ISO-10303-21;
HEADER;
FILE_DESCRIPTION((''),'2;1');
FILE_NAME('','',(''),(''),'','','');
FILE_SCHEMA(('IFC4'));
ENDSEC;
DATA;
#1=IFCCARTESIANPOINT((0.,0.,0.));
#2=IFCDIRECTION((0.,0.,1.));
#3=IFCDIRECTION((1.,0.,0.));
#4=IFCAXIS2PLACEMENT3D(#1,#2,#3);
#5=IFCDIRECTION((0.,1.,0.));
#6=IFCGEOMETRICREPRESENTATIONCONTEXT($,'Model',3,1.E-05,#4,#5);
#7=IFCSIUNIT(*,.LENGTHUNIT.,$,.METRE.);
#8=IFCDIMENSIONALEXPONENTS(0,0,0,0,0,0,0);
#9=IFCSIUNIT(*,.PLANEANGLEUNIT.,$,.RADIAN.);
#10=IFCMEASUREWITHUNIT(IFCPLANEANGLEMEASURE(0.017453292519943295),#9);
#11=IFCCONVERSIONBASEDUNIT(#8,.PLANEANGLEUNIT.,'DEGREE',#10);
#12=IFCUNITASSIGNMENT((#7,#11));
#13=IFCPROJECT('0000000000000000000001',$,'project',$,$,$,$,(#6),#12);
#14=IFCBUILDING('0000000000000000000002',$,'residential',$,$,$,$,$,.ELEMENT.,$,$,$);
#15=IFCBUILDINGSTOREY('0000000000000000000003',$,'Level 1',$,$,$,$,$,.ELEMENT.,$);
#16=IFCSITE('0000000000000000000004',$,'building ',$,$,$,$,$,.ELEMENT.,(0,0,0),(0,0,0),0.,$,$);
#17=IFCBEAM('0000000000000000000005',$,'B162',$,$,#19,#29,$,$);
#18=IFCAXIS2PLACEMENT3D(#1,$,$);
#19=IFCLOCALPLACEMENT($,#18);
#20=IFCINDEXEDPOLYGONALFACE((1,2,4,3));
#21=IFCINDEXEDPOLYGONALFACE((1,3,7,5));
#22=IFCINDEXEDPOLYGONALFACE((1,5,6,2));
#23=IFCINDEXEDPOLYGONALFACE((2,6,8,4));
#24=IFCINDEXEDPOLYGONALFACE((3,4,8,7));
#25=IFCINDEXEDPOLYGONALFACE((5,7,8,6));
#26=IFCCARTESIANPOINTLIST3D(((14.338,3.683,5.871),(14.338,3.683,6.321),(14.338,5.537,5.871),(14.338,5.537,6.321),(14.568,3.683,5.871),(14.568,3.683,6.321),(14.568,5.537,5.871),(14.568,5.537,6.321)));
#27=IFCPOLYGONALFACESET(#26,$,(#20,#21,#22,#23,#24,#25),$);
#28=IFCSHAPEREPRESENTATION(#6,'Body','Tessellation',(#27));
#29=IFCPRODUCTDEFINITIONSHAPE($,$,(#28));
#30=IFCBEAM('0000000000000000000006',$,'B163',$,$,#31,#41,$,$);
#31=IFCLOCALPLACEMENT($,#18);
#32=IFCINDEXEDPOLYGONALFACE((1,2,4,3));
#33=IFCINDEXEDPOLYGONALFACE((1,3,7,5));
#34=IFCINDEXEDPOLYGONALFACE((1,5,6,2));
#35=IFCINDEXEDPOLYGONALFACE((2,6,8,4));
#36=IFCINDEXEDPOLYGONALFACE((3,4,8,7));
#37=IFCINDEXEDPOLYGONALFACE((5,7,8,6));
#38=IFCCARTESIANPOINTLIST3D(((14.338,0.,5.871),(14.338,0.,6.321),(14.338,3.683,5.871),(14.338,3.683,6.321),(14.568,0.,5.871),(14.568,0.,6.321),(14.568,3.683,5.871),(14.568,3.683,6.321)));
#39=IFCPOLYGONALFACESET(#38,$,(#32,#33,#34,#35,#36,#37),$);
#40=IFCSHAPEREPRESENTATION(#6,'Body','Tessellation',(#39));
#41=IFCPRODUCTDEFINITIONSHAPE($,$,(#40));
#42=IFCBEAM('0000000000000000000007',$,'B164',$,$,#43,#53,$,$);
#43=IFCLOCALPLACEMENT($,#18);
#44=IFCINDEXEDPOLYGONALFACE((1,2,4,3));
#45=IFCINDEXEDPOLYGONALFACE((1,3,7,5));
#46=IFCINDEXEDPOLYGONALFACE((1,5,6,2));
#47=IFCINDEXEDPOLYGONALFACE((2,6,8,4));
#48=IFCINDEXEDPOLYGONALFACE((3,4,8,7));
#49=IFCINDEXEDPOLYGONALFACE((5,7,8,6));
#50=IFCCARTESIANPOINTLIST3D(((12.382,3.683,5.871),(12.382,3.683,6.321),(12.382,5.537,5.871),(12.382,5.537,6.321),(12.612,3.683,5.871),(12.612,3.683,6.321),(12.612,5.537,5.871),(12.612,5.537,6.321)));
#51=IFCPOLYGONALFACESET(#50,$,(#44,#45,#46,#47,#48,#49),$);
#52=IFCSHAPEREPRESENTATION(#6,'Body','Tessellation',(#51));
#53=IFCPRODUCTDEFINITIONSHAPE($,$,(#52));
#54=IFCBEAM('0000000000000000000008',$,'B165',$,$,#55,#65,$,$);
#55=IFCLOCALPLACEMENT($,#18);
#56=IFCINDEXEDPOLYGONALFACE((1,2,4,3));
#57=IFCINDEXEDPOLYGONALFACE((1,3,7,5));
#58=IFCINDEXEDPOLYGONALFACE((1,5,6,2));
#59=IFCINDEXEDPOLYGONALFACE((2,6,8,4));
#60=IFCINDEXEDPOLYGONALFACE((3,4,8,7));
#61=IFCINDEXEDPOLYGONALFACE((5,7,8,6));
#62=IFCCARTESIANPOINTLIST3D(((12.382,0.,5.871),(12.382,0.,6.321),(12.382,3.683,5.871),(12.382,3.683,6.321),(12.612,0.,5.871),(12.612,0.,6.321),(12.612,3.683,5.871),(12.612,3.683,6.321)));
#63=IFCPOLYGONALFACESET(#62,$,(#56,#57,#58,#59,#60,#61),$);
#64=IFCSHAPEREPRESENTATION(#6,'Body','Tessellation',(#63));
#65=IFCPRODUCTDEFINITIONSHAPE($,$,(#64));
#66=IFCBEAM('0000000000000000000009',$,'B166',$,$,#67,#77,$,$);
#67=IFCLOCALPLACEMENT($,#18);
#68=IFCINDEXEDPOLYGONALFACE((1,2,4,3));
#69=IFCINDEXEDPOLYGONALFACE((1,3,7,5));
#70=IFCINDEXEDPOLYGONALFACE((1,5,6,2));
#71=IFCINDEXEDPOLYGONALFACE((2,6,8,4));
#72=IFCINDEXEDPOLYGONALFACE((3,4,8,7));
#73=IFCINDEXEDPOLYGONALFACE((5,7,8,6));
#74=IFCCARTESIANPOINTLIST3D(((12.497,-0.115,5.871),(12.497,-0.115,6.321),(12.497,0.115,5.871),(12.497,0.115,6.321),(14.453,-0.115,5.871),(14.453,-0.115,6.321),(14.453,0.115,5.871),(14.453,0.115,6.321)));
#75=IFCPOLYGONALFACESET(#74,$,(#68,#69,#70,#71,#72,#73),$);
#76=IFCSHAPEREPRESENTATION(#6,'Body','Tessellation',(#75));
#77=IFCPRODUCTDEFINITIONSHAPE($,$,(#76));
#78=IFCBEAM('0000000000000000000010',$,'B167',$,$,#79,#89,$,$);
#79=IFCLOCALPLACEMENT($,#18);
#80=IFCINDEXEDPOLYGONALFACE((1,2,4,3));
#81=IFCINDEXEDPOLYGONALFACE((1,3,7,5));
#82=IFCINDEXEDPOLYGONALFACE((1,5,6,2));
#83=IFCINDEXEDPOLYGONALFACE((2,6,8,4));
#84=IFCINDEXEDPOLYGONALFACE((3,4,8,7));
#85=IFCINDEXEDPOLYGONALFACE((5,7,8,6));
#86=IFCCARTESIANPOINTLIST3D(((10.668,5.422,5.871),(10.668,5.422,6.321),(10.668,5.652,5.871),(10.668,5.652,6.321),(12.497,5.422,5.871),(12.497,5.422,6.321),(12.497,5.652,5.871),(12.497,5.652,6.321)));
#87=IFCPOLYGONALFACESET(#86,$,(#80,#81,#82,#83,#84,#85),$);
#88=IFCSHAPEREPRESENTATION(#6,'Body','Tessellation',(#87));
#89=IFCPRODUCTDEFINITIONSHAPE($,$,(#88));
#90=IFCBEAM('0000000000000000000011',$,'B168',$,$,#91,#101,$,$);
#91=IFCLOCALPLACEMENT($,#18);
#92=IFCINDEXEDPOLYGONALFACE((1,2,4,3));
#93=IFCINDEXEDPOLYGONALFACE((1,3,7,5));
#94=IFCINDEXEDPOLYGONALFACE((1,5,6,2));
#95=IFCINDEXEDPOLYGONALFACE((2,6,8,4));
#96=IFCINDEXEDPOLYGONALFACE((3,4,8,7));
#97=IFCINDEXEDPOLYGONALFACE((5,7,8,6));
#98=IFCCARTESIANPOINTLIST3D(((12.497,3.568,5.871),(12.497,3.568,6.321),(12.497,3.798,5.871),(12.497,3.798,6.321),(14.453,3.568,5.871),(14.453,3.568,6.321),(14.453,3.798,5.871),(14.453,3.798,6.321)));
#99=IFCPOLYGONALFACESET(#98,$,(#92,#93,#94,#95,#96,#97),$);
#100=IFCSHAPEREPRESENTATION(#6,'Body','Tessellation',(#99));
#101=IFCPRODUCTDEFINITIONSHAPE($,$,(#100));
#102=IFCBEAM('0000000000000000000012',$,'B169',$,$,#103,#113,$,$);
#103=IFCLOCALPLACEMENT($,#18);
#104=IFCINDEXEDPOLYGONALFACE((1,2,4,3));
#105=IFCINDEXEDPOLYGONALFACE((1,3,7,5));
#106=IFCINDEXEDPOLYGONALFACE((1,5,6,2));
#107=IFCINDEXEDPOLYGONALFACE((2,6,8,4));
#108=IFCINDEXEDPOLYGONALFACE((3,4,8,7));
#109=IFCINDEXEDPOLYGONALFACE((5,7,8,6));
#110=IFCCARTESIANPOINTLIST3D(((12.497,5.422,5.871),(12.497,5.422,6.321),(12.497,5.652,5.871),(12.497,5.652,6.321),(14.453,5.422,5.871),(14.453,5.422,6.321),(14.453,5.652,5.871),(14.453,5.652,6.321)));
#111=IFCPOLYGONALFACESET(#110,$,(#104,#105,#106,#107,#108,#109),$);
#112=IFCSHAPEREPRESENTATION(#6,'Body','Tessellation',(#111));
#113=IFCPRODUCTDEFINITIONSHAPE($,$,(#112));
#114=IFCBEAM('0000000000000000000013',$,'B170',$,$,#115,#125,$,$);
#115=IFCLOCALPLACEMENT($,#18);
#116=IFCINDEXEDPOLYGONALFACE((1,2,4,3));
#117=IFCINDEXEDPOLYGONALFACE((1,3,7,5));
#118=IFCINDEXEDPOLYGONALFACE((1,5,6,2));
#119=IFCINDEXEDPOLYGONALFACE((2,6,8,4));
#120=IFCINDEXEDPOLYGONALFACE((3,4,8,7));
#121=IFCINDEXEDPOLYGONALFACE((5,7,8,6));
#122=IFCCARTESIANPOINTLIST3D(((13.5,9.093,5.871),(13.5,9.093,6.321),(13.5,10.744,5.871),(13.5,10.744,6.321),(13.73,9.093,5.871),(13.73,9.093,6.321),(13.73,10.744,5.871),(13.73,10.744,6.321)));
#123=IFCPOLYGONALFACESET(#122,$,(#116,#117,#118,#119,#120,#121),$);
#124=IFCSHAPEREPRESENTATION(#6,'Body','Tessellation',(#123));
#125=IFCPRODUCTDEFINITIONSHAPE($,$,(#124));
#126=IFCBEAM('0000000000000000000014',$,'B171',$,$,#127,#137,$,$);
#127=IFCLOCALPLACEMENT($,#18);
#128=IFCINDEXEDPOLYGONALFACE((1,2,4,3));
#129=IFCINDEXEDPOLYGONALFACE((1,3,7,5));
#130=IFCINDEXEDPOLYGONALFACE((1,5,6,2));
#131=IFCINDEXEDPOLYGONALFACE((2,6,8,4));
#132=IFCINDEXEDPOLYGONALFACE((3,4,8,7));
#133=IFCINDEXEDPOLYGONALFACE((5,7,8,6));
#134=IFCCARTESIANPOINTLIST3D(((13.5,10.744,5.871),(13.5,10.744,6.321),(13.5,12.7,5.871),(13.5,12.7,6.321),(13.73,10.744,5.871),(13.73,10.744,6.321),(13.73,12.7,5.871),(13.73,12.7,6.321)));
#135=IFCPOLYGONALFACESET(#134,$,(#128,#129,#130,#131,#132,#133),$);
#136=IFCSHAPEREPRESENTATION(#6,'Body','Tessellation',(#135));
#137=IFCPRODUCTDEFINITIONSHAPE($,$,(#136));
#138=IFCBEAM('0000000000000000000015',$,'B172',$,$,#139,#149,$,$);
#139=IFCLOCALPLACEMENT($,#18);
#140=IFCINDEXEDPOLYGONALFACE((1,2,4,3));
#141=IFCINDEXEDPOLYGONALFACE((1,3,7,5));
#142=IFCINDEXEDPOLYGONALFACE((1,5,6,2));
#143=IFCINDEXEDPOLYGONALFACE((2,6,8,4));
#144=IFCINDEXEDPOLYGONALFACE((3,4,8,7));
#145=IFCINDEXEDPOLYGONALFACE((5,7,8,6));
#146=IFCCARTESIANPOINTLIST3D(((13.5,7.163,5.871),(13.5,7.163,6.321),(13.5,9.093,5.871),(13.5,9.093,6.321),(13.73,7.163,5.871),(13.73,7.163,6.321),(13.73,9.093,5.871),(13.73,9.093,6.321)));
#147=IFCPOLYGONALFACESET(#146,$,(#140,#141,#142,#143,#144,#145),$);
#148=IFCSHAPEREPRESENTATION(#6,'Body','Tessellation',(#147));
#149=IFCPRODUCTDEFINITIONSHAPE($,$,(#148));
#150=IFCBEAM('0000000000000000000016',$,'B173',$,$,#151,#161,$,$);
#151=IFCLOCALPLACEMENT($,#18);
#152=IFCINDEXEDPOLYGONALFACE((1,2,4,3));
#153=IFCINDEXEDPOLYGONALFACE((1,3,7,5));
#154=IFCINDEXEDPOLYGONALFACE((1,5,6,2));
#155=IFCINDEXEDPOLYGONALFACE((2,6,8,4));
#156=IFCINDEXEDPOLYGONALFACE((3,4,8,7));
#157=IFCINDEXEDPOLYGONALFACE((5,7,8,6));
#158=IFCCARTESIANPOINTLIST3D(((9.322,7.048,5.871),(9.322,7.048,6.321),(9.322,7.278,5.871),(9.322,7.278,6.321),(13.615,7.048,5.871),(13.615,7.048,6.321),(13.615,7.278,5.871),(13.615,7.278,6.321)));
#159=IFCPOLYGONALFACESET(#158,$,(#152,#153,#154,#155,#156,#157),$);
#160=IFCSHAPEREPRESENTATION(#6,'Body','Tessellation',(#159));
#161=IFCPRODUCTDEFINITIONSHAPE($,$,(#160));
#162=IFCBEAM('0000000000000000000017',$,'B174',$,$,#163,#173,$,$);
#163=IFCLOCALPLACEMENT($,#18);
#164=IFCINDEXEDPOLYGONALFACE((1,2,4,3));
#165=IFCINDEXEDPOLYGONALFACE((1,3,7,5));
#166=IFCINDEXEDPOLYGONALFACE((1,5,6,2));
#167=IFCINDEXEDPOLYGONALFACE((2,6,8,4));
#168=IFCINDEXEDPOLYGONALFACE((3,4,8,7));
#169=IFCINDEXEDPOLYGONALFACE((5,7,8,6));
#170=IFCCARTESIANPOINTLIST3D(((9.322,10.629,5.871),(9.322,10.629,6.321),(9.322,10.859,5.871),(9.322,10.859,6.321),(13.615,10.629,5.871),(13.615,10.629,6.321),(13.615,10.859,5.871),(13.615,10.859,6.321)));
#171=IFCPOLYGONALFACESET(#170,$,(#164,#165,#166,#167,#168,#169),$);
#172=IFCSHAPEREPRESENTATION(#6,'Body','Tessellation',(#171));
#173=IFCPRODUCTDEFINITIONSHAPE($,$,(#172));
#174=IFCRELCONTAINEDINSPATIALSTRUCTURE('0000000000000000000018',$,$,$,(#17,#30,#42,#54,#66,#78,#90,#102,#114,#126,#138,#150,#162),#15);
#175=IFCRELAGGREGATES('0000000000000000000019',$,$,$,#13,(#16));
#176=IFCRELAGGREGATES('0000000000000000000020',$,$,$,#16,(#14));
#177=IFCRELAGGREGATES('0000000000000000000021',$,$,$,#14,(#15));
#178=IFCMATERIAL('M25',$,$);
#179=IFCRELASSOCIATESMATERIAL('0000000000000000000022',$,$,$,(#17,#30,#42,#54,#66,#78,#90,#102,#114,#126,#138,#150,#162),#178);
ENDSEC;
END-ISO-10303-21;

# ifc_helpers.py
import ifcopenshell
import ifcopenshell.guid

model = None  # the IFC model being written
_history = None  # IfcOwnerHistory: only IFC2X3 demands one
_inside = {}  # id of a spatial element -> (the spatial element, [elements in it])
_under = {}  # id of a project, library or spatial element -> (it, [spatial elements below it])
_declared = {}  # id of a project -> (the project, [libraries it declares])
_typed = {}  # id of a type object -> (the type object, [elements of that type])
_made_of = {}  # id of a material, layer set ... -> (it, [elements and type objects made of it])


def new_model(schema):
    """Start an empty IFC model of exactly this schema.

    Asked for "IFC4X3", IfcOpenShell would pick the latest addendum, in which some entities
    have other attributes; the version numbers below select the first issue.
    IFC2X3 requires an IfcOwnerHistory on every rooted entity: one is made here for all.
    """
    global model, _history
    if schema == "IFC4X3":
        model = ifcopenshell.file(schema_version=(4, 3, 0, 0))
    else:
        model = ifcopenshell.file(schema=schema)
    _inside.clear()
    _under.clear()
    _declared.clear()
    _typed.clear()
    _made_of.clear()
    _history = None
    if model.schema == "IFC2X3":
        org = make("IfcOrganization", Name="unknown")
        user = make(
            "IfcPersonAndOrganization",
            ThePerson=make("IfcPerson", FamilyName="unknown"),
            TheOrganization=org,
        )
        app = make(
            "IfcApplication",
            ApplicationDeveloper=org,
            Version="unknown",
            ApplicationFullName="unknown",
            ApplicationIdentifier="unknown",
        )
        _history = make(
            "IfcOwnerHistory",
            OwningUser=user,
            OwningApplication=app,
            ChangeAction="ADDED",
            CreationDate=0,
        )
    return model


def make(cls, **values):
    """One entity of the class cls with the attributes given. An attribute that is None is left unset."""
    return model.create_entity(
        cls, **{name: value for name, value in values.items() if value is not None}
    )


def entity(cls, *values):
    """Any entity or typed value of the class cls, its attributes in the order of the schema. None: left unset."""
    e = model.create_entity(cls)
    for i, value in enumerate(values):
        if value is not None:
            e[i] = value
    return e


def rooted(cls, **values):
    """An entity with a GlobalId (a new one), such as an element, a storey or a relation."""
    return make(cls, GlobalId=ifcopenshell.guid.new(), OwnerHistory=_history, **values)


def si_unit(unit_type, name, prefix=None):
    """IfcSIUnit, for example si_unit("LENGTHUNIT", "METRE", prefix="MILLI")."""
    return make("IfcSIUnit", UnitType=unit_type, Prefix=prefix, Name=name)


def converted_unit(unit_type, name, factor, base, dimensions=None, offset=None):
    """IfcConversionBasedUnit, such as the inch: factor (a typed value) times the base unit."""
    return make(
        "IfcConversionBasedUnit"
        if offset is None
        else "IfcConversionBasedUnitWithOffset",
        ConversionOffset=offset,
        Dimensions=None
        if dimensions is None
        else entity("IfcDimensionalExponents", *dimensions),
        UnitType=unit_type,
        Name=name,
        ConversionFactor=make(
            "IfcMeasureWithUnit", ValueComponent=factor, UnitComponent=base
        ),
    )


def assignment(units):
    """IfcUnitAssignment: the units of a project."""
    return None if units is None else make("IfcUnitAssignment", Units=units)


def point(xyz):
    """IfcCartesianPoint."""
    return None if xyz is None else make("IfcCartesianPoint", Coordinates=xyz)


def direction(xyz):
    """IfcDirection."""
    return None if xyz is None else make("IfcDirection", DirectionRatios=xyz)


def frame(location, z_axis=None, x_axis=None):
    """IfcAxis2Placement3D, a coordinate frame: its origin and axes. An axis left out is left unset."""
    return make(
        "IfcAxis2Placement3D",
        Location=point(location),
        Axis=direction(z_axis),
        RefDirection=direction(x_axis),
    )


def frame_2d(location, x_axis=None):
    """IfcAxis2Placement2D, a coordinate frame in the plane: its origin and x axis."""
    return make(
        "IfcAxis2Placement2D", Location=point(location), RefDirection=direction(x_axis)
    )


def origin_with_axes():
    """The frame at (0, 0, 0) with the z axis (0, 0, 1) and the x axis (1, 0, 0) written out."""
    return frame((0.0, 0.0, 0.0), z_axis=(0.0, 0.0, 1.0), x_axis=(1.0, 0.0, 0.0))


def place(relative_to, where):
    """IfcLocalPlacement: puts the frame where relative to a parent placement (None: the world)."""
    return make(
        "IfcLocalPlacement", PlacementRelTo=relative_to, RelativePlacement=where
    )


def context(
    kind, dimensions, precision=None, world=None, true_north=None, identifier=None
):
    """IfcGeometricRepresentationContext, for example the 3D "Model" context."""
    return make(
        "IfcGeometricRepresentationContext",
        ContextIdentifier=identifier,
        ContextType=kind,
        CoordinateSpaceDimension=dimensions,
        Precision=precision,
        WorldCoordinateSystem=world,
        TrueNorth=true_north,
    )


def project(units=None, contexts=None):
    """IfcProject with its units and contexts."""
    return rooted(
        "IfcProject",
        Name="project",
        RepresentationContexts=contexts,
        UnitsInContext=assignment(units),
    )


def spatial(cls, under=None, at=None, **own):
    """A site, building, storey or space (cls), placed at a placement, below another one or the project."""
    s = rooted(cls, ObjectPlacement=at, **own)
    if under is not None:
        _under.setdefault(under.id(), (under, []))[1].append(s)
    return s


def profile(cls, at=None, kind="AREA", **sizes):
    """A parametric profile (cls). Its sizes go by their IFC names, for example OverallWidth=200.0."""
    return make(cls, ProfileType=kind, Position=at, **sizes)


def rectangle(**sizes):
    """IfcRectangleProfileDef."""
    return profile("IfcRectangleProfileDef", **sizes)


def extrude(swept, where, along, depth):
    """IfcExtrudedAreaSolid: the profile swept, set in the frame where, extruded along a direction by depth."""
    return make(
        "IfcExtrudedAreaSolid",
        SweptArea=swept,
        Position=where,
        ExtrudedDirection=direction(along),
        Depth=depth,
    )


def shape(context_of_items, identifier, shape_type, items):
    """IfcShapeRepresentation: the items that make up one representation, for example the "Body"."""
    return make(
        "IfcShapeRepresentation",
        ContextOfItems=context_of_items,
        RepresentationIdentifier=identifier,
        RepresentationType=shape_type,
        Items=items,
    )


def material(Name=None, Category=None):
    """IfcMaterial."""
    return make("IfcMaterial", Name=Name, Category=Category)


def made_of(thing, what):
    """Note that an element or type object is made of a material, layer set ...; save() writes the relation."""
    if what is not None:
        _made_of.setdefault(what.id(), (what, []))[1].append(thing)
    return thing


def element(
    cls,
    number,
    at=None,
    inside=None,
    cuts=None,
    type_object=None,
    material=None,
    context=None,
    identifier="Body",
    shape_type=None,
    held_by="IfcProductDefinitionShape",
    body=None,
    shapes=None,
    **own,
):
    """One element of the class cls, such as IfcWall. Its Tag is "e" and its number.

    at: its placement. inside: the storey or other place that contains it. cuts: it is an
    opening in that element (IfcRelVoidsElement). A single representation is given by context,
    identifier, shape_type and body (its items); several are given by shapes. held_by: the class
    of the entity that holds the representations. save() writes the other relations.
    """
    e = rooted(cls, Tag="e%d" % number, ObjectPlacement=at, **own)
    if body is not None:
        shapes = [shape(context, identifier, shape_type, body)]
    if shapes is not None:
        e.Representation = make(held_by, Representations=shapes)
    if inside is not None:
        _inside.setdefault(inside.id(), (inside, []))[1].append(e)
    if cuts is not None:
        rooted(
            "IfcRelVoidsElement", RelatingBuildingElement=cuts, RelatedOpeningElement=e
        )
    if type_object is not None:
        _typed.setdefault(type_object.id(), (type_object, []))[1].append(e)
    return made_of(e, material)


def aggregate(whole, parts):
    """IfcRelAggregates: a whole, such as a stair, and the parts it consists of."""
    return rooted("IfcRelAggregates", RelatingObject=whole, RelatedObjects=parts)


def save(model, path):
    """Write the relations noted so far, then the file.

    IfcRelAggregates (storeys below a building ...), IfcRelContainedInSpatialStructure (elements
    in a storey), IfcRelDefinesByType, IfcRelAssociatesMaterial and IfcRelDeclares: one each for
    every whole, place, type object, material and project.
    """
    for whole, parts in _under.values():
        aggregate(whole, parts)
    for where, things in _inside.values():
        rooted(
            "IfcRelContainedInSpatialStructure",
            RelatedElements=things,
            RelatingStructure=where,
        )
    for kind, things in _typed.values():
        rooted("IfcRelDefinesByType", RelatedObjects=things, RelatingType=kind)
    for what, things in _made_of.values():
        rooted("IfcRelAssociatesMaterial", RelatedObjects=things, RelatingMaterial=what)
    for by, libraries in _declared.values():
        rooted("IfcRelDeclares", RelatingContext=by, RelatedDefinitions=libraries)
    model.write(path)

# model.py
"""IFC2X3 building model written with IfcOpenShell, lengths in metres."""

from ifc_helpers import new_model, entity, si_unit, converted_unit, direction, frame, frame_2d, origin_with_axes, place, context, project, spatial, rectangle, extrude, material, element, save


model = new_model("IFC2X3")

# Units and contexts
model_context = context("Model", 3, precision=1e-05, world=origin_with_axes(), true_north=direction((0.0, 1.0, 0.0)))
ifc_project = project(units=[si_unit("LENGTHUNIT", "METRE"), converted_unit("PLANEANGLEUNIT", "DEGREE", entity("IfcPlaneAngleMeasure", 0.017453292519943295), si_unit("PLANEANGLEUNIT", "RADIAN"), dimensions=[0, 0, 0, 0, 0, 0, 0])], contexts=[model_context])

# Site, building, storey
site = spatial("IfcSite", under=ifc_project, Name="building ", CompositionType="ELEMENT", RefLatitude=(0, 0, 0), RefLongitude=(0, 0, 0), RefElevation=0.0)
building = spatial("IfcBuilding", under=site, Name="residential", CompositionType="ELEMENT")
storey = spatial("IfcBuildingStorey", under=building, Name="Level 1", CompositionType="ELEMENT")

# Shared definitions
ifc_material = material(Name="M25")
placement = place(None, origin_with_axes())

# Beams
element("IfcBeam", 1, at=placement, inside=storey, material=ifc_material, Name="B162", context=model_context, shape_type="SweptSolid", body=[
    extrude(rectangle(XDim=0.23, YDim=0.45, at=frame_2d((0.0, 0.0), x_axis=(0.0, 1.0, 0.0))), frame((14.453, 3.683, 6.096), z_axis=(0.0, 1.0, 0.0), x_axis=(0.0, 0.0, -1.0)), (0.0, 0.0, 1.0), 1.854),
])
element("IfcBeam", 2, at=placement, inside=storey, material=ifc_material, Name="B163", context=model_context, shape_type="SweptSolid", body=[
    extrude(rectangle(XDim=0.23, YDim=0.45, at=frame_2d((0.0, 0.0), x_axis=(0.0, 1.0, 0.0))), frame((14.453, 0.0, 6.096), z_axis=(0.0, 1.0, 0.0), x_axis=(0.0, 0.0, -1.0)), (0.0, 0.0, 1.0), 3.683),
])
element("IfcBeam", 3, at=placement, inside=storey, material=ifc_material, Name="B164", context=model_context, shape_type="SweptSolid", body=[
    extrude(rectangle(XDim=0.23, YDim=0.45, at=frame_2d((0.0, 0.0), x_axis=(0.0, 1.0, 0.0))), frame((12.497, 3.683, 6.096), z_axis=(0.0, 1.0, 0.0), x_axis=(0.0, 0.0, -1.0)), (0.0, 0.0, 1.0), 1.854),
])
element("IfcBeam", 4, at=placement, inside=storey, material=ifc_material, Name="B165", context=model_context, shape_type="SweptSolid", body=[
    extrude(rectangle(XDim=0.23, YDim=0.45, at=frame_2d((0.0, 0.0), x_axis=(0.0, 1.0, 0.0))), frame((12.497, 0.0, 6.096), z_axis=(0.0, 1.0, 0.0), x_axis=(0.0, 0.0, -1.0)), (0.0, 0.0, 1.0), 3.683),
])
element("IfcBeam", 5, at=placement, inside=storey, material=ifc_material, Name="B166", context=model_context, shape_type="SweptSolid", body=[
    extrude(rectangle(XDim=0.23, YDim=0.45, at=frame_2d((0.0, 0.0), x_axis=(0.0, 1.0, 0.0))), frame((12.497, 0.0, 6.096), z_axis=(1.0, 0.0, 0.0), x_axis=(0.0, 0.0, -1.0)), (0.0, 0.0, 1.0), 1.956),
])
element("IfcBeam", 6, at=placement, inside=storey, material=ifc_material, Name="B167", context=model_context, shape_type="SweptSolid", body=[
    extrude(rectangle(XDim=0.23, YDim=0.45, at=frame_2d((0.0, 0.0), x_axis=(0.0, 1.0, 0.0))), frame((10.668, 5.537, 6.096), z_axis=(1.0, 0.0, 0.0), x_axis=(0.0, 0.0, -1.0)), (0.0, 0.0, 1.0), 1.829),
])
element("IfcBeam", 7, at=placement, inside=storey, material=ifc_material, Name="B168", context=model_context, shape_type="SweptSolid", body=[
    extrude(rectangle(XDim=0.23, YDim=0.45, at=frame_2d((0.0, 0.0), x_axis=(0.0, 1.0, 0.0))), frame((12.497, 3.683, 6.096), z_axis=(1.0, 0.0, 0.0), x_axis=(0.0, 0.0, -1.0)), (0.0, 0.0, 1.0), 1.956),
])
element("IfcBeam", 8, at=placement, inside=storey, material=ifc_material, Name="B169", context=model_context, shape_type="SweptSolid", body=[
    extrude(rectangle(XDim=0.23, YDim=0.45, at=frame_2d((0.0, 0.0), x_axis=(0.0, 1.0, 0.0))), frame((12.497, 5.537, 6.096), z_axis=(1.0, 0.0, 0.0), x_axis=(0.0, 0.0, -1.0)), (0.0, 0.0, 1.0), 1.956),
])
element("IfcBeam", 9, at=placement, inside=storey, material=ifc_material, Name="B170", context=model_context, shape_type="SweptSolid", body=[
    extrude(rectangle(XDim=0.23, YDim=0.45, at=frame_2d((0.0, 0.0), x_axis=(0.0, 1.0, 0.0))), frame((13.615, 9.093, 6.096), z_axis=(0.0, 1.0, 0.0), x_axis=(0.0, 0.0, -1.0)), (0.0, 0.0, 1.0), 1.651),
])
element("IfcBeam", 10, at=placement, inside=storey, material=ifc_material, Name="B171", context=model_context, shape_type="SweptSolid", body=[
    extrude(rectangle(XDim=0.23, YDim=0.45, at=frame_2d((0.0, 0.0), x_axis=(0.0, 1.0, 0.0))), frame((13.615, 10.744, 6.096), z_axis=(0.0, 1.0, 0.0), x_axis=(0.0, 0.0, -1.0)), (0.0, 0.0, 1.0), 1.956),
])
element("IfcBeam", 11, at=placement, inside=storey, material=ifc_material, Name="B172", context=model_context, shape_type="SweptSolid", body=[
    extrude(rectangle(XDim=0.23, YDim=0.45, at=frame_2d((0.0, 0.0), x_axis=(0.0, 1.0, 0.0))), frame((13.615, 7.163, 6.096), z_axis=(0.0, 1.0, 0.0), x_axis=(0.0, 0.0, -1.0)), (0.0, 0.0, 1.0), 1.93),
])
element("IfcBeam", 12, at=placement, inside=storey, material=ifc_material, Name="B173", context=model_context, shape_type="SweptSolid", body=[
    extrude(rectangle(XDim=0.23, YDim=0.45, at=frame_2d((0.0, 0.0), x_axis=(0.0, 1.0, 0.0))), frame((9.322, 7.163, 6.096), z_axis=(1.0, 0.0, 0.0), x_axis=(0.0, 0.0, -1.0)), (0.0, 0.0, 1.0), 4.293),
])
element("IfcBeam", 13, at=placement, inside=storey, material=ifc_material, Name="B174", context=model_context, shape_type="SweptSolid", body=[
    extrude(rectangle(XDim=0.23, YDim=0.45, at=frame_2d((0.0, 0.0), x_axis=(0.0, 1.0, 0.0))), frame((9.322, 10.744, 6.096), z_axis=(1.0, 0.0, 0.0), x_axis=(0.0, 0.0, -1.0)), (0.0, 0.0, 1.0), 4.293),
])

save(model, "model.ifc")
